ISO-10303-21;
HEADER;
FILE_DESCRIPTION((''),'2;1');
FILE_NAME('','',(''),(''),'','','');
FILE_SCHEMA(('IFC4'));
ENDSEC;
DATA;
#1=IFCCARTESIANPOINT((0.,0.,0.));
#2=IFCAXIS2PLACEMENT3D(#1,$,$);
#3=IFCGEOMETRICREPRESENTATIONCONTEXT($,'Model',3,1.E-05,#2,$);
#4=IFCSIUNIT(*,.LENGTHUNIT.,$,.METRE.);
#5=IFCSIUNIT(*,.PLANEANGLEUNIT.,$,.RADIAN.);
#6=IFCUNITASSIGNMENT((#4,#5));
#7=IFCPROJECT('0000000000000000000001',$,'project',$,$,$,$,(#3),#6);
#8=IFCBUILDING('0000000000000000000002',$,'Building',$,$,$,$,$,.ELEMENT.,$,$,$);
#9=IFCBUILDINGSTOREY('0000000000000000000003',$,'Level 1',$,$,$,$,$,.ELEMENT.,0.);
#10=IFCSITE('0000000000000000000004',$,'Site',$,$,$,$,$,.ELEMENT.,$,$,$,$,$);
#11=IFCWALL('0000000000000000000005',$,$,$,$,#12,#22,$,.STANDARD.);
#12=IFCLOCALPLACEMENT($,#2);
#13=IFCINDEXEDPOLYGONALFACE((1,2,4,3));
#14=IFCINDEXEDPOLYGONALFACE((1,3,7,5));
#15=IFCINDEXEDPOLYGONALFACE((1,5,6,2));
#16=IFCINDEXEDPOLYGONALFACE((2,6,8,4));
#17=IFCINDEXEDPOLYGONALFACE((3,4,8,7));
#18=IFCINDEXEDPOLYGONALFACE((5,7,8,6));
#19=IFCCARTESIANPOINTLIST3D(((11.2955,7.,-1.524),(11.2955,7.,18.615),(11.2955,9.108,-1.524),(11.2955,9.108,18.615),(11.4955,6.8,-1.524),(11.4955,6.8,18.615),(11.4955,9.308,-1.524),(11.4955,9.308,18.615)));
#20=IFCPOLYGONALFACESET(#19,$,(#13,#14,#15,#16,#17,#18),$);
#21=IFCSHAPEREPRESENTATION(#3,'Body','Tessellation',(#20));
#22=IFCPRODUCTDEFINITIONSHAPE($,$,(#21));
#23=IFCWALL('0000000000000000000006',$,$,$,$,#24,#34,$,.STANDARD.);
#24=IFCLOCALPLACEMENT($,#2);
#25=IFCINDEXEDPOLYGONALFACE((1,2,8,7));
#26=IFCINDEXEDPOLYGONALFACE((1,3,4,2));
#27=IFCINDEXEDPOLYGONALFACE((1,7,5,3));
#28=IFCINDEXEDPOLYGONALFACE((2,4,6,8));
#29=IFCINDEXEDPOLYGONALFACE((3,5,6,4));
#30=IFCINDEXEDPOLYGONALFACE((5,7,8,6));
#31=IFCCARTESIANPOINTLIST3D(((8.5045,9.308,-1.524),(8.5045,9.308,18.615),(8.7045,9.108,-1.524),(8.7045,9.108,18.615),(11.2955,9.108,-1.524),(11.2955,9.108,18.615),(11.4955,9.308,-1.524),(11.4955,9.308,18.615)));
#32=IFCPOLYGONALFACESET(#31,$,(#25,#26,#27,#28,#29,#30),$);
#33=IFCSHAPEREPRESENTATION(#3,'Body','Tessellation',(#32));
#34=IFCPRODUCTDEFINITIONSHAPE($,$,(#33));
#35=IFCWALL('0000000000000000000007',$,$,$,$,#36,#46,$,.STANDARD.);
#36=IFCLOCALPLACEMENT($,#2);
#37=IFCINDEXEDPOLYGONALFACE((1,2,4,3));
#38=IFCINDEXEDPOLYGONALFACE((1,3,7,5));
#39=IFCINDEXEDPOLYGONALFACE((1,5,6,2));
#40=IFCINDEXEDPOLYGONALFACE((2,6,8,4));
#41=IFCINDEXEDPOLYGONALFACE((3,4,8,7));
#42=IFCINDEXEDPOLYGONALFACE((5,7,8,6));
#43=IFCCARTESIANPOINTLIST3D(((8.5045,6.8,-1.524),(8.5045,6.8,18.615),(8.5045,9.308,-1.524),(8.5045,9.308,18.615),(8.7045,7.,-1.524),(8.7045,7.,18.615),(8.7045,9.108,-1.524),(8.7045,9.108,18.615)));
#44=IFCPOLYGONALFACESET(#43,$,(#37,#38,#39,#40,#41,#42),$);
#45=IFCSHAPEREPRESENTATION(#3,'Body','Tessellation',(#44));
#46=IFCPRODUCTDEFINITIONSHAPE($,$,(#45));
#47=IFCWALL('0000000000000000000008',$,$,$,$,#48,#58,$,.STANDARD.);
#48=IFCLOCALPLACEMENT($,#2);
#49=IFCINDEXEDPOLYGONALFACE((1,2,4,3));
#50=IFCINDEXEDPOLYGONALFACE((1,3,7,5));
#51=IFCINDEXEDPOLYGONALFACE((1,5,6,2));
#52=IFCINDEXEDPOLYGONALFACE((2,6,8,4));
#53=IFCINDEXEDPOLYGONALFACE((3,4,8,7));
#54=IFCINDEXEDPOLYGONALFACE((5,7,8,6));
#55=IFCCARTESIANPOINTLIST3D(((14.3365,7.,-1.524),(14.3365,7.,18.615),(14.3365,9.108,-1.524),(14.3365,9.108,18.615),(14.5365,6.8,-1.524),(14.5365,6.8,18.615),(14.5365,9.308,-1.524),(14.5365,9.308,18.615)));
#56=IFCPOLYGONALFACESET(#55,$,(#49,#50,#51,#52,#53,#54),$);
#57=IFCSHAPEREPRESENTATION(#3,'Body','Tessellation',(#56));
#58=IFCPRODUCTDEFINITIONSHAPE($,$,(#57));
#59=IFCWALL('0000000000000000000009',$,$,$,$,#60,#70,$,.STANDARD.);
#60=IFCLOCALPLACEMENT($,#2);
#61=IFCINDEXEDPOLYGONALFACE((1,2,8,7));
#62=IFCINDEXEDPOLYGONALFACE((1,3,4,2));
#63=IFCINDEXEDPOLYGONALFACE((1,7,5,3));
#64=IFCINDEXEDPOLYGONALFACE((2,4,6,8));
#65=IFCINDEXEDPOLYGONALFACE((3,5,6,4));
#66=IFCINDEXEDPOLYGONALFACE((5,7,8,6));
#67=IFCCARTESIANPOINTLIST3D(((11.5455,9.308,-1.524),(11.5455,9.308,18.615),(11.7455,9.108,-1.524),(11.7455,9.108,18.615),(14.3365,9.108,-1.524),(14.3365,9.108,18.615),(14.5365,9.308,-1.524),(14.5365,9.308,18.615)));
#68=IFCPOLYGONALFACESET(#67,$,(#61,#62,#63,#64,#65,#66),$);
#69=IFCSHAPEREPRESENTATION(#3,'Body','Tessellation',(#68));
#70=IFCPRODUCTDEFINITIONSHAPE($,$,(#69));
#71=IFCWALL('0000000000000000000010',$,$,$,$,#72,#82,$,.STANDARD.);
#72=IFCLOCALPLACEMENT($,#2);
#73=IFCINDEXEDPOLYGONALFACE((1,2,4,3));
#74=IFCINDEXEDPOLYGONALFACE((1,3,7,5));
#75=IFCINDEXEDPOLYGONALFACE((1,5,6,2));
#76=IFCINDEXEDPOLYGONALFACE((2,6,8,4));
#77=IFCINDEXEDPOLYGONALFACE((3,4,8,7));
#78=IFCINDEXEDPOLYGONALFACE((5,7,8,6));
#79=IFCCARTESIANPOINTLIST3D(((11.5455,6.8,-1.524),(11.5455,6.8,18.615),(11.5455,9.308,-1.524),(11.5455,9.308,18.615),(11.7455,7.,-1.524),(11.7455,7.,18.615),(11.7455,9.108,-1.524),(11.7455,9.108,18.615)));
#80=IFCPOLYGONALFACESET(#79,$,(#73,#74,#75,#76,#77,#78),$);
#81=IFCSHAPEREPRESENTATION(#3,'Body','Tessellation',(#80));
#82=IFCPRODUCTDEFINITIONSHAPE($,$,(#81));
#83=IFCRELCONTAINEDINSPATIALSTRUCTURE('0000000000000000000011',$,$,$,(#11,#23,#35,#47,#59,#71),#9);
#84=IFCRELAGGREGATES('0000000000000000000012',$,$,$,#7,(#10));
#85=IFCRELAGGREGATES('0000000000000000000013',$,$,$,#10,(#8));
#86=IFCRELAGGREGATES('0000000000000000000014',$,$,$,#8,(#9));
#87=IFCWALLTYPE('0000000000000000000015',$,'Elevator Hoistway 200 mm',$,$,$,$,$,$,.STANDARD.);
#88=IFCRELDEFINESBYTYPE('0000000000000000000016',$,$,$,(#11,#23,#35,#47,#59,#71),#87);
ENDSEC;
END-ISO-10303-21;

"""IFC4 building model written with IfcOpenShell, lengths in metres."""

from ifc_helpers import new_model, si_unit, frame, origin, place, context, project, spatial, polyline, outline, extrude, type_object, element, save


model = new_model("IFC4")

# Units and contexts
model_context = context("Model", 3, precision=1e-05, world=origin())
ifc_project = project(units=[si_unit("LENGTHUNIT", "METRE"), si_unit("PLANEANGLEUNIT", "RADIAN")], contexts=[model_context])

# Site, building, storey
site = spatial("IfcSite", under=ifc_project, Name="Site", CompositionType="ELEMENT")
building = spatial("IfcBuilding", under=site, Name="Building", CompositionType="ELEMENT")
storey = spatial("IfcBuildingStorey", under=building, Name="Level 1", CompositionType="ELEMENT", Elevation=0.0)

# Shared definitions
wall_type = type_object("IfcWallType", Name="Elevator Hoistway 200 mm", PredefinedType="STANDARD")

# Walls
wall_1_placement = place(None, frame((11.3955, 6.9, -1.524), z_axis=(0.0, 0.0, 1.0), x_axis=(0.0, 1.0, 0.0)))
element("IfcWall", 1, at=wall_1_placement, inside=storey, type_object=wall_type, PredefinedType="STANDARD", context=model_context, shape_type="SweptSolid", body=[
    extrude(outline(polyline([(-0.1, -0.1), (2.408, -0.1), (2.208, 0.1), (0.1, 0.1), (-0.1, -0.1)])), origin(), (0.0, 0.0, 1.0), 20.139),
])
wall_2_placement = place(None, frame((11.3955, 9.208, -1.524), z_axis=(0.0, 0.0, 1.0), x_axis=(-1.0, 0.0, 0.0)))
element("IfcWall", 2, at=wall_2_placement, inside=storey, type_object=wall_type, PredefinedType="STANDARD", context=model_context, shape_type="SweptSolid", body=[
    extrude(outline(polyline([(-0.1, -0.1), (2.891, -0.1), (2.691, 0.1), (0.1, 0.1), (-0.1, -0.1)])), origin(), (0.0, 0.0, 1.0), 20.139),
])
wall_3_placement = place(None, frame((8.6045, 9.208, -1.524), z_axis=(0.0, 0.0, 1.0), x_axis=(0.0, -1.0, 0.0)))
element("IfcWall", 3, at=wall_3_placement, inside=storey, type_object=wall_type, PredefinedType="STANDARD", context=model_context, shape_type="SweptSolid", body=[
    extrude(outline(polyline([(-0.1, -0.1), (2.408, -0.1), (2.208, 0.1), (0.1, 0.1), (-0.1, -0.1)])), origin(), (0.0, 0.0, 1.0), 20.139),
])

# Walls
wall_4_placement = place(None, frame((14.4365, 6.9, -1.524), z_axis=(0.0, 0.0, 1.0), x_axis=(0.0, 1.0, 0.0)))
element("IfcWall", 4, at=wall_4_placement, inside=storey, type_object=wall_type, PredefinedType="STANDARD", context=model_context, shape_type="SweptSolid", body=[
    extrude(outline(polyline([(-0.1, -0.1), (2.408, -0.1), (2.208, 0.1), (0.1, 0.1), (-0.1, -0.1)])), origin(), (0.0, 0.0, 1.0), 20.139),
])
wall_5_placement = place(None, frame((14.4365, 9.208, -1.524), z_axis=(0.0, 0.0, 1.0), x_axis=(-1.0, 0.0, 0.0)))
element("IfcWall", 5, at=wall_5_placement, inside=storey, type_object=wall_type, PredefinedType="STANDARD", context=model_context, shape_type="SweptSolid", body=[
    extrude(outline(polyline([(-0.1, -0.1), (2.891, -0.1), (2.691, 0.1), (0.1, 0.1), (-0.1, -0.1)])), origin(), (0.0, 0.0, 1.0), 20.139),
])
wall_6_placement = place(None, frame((11.6455, 9.208, -1.524), z_axis=(0.0, 0.0, 1.0), x_axis=(0.0, -1.0, 0.0)))
element("IfcWall", 6, at=wall_6_placement, inside=storey, type_object=wall_type, PredefinedType="STANDARD", context=model_context, shape_type="SweptSolid", body=[
    extrude(outline(polyline([(-0.1, -0.1), (2.408, -0.1), (2.208, 0.1), (0.1, 0.1), (-0.1, -0.1)])), origin(), (0.0, 0.0, 1.0), 20.139),
])

save(model, "model.ifc")
